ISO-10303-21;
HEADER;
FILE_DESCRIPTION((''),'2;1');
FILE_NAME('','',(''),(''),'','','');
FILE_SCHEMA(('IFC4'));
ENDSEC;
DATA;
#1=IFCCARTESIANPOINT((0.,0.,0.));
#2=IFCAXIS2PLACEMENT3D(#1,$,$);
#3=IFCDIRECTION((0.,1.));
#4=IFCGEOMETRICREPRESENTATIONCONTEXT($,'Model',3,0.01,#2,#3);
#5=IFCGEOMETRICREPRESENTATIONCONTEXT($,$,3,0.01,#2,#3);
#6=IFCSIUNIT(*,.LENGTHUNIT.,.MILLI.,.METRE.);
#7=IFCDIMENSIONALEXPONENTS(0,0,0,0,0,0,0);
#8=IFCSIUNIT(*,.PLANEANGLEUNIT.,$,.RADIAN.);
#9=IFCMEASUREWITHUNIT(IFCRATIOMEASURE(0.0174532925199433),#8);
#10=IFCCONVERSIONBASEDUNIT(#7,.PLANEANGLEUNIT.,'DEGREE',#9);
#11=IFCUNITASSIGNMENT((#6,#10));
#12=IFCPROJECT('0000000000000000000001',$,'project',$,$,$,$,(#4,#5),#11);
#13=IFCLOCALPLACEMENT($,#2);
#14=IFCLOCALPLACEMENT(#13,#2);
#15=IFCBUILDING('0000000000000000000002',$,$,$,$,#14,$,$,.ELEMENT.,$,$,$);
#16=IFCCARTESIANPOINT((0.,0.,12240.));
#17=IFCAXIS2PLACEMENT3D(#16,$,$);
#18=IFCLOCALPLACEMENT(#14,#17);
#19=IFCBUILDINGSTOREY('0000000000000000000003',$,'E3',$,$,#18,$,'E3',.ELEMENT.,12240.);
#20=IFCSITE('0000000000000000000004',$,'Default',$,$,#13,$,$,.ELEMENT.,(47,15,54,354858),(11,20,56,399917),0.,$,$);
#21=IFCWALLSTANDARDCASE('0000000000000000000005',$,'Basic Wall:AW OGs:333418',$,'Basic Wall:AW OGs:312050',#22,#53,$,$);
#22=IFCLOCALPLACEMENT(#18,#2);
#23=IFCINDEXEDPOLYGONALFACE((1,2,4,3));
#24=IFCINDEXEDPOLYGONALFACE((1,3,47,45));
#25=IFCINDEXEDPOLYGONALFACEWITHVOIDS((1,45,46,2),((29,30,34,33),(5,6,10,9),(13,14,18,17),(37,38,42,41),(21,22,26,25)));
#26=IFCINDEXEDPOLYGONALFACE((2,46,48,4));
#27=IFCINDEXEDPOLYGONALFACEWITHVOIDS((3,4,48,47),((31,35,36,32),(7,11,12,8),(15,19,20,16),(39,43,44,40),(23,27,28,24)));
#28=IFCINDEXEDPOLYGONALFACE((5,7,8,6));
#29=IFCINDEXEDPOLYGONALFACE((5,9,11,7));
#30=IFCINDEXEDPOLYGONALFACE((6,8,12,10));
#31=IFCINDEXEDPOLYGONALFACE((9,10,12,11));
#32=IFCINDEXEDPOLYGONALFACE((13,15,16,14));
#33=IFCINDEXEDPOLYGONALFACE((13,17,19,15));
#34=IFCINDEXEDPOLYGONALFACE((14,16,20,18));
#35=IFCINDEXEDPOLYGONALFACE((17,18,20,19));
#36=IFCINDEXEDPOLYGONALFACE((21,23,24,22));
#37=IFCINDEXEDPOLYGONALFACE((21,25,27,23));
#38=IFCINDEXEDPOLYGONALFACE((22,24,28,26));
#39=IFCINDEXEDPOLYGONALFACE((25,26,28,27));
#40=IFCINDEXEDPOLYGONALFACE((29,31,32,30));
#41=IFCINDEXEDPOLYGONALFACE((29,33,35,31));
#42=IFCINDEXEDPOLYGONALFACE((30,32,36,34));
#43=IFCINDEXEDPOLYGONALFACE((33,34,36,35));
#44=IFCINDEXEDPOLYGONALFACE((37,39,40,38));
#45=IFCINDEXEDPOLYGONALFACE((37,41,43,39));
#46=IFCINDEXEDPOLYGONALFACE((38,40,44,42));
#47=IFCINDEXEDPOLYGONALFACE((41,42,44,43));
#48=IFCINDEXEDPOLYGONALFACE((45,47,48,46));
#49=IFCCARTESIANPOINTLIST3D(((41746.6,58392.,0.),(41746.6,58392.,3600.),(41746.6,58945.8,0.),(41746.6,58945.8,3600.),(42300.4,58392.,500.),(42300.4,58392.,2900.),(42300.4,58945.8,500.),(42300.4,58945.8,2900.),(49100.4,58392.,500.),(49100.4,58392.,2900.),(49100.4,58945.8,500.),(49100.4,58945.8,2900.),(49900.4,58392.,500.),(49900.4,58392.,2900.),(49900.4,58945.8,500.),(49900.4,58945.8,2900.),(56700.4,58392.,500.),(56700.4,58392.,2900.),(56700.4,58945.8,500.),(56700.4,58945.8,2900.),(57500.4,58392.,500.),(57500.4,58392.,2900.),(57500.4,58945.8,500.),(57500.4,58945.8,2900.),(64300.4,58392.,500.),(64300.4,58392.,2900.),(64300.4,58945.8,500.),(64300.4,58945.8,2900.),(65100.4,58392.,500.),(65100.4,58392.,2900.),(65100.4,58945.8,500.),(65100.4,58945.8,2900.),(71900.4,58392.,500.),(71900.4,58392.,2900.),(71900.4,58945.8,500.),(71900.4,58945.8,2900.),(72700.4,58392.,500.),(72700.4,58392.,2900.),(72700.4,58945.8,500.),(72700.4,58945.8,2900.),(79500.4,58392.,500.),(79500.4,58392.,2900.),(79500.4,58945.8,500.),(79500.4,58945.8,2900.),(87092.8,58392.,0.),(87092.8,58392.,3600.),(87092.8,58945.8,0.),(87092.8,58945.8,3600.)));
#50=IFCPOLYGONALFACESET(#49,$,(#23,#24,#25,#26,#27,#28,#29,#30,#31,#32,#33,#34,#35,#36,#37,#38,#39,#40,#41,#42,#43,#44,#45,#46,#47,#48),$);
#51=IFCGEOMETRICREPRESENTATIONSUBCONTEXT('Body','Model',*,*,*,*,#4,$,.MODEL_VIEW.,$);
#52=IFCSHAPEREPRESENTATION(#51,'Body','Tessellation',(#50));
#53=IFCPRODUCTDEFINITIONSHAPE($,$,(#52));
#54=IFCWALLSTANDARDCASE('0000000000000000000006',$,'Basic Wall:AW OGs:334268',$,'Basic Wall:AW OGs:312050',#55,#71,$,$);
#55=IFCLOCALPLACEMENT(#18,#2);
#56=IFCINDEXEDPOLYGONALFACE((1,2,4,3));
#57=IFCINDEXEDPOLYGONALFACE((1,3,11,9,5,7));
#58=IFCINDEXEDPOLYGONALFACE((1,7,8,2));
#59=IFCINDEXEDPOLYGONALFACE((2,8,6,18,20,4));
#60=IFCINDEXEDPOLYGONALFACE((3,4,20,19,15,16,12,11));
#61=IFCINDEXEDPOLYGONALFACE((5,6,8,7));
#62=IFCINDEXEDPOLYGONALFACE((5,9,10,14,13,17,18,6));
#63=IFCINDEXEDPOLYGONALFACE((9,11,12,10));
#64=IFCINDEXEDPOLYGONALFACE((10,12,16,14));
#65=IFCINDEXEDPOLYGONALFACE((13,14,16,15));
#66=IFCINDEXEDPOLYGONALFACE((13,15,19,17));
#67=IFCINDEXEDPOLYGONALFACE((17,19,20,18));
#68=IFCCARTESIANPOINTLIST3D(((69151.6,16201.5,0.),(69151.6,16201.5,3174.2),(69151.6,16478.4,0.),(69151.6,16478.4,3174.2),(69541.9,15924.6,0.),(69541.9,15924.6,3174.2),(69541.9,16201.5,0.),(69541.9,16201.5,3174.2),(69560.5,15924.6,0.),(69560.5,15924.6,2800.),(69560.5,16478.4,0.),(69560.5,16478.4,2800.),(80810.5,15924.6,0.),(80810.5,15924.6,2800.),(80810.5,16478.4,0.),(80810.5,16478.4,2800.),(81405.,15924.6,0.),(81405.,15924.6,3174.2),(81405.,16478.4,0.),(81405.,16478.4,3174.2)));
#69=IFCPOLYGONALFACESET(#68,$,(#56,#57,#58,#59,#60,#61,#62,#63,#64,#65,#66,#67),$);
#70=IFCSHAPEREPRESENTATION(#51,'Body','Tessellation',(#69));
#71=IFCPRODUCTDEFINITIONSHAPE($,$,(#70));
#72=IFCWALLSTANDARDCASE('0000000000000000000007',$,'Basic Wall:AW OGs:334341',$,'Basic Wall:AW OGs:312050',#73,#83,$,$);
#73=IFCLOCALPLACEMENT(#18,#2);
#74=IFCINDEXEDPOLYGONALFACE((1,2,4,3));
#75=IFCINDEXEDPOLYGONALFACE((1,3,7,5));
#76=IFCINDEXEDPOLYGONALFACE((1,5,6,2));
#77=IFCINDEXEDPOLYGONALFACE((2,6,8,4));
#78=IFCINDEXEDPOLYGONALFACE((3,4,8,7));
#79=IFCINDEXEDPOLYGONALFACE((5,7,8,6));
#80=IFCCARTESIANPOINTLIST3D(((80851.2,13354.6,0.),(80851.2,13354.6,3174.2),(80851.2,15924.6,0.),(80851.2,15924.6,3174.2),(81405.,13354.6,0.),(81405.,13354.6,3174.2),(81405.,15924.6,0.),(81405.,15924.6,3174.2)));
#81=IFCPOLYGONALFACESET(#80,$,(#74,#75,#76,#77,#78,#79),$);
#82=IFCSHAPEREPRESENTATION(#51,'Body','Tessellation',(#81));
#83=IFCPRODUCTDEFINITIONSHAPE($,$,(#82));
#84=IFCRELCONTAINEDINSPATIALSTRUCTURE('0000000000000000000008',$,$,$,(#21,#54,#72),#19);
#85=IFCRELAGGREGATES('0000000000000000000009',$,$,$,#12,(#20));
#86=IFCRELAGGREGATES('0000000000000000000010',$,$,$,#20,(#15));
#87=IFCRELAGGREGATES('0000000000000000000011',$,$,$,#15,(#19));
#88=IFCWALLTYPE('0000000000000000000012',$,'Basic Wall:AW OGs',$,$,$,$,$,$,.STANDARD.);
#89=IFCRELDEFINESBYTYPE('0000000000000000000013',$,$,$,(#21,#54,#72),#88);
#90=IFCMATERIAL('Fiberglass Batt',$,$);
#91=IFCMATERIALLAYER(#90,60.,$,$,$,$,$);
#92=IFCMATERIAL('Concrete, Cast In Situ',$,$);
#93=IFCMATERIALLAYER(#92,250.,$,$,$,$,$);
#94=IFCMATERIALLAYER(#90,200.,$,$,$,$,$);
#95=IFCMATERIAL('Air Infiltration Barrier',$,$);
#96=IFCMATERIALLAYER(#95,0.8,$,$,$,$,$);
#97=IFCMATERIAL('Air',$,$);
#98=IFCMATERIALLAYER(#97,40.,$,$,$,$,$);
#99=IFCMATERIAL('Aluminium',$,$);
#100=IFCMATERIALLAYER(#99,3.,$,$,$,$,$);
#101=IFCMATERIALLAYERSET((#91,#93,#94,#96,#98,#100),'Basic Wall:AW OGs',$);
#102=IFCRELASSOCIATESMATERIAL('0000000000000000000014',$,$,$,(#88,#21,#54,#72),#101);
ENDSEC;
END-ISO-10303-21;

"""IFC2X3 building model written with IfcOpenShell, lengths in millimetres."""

from ifc_helpers import new_model, entity, si_unit, converted_unit, direction, frame, frame_2d, origin, place, context, subcontext, project, spatial, polyline, rectangle, outline, extrude, clip, bounded_halfspace, material, layer, layer_set, layer_usage, type_object, element, save


model = new_model("IFC2X3")

# Units and contexts
model_context = context("Model", 3, precision=0.01, world=origin(), true_north=direction((0.0, 1.0)))
context_of_model = context(None, 3, precision=0.01, world=origin(), true_north=direction((0.0, 1.0)))
body_context = subcontext(model_context, "Body", "Model", "MODEL_VIEW")
ifc_project = project(units=[si_unit("LENGTHUNIT", "METRE", prefix="MILLI"), converted_unit("PLANEANGLEUNIT", "DEGREE", entity("IfcRatioMeasure", 0.0174532925199433), si_unit("PLANEANGLEUNIT", "RADIAN"), dimensions=[0, 0, 0, 0, 0, 0, 0])], contexts=[model_context, context_of_model])

# Site, building, storey
site_placement = place(None, origin())
site = spatial("IfcSite", under=ifc_project, at=site_placement, Name="Default", CompositionType="ELEMENT", RefLatitude=(47, 15, 54, 354858), RefLongitude=(11, 20, 56, 399917), RefElevation=0.0)
building_placement = place(site_placement, origin())
building = spatial("IfcBuilding", under=site, at=building_placement, CompositionType="ELEMENT")
storey_placement = place(building_placement, frame((0.0, 0.0, 12240.0)))
storey = spatial("IfcBuildingStorey", under=building, at=storey_placement, Name="E3", LongName="E3", CompositionType="ELEMENT", Elevation=12240.0)

# Shared definitions
ifc_material_1 = material(Name="Concrete, Cast In Situ")

# Shared definitions
ifc_material_2 = material(Name="Fiberglass Batt")
ifc_layer_1 = layer(ifc_material_2, 60.0)
ifc_layer_2 = layer(ifc_material_1, 250.0)
ifc_layer_3 = layer(ifc_material_2, 200.0)
ifc_material_3 = material(Name="Air Infiltration Barrier")
ifc_layer_4 = layer(ifc_material_3, 0.8)
ifc_material_4 = material(Name="Air")
ifc_layer_5 = layer(ifc_material_4, 40.0)
ifc_material_5 = material(Name="Aluminium")
ifc_layer_6 = layer(ifc_material_5, 3.0)
ifc_layer_set_1 = layer_set([ifc_layer_1, ifc_layer_2, ifc_layer_3, ifc_layer_4, ifc_layer_5, ifc_layer_6], Name="Basic Wall:AW OGs")
wall_type_1 = type_object("IfcWallType", Name="Basic Wall:AW OGs", PredefinedType="STANDARD", material=ifc_layer_set_1)

# Wall, openings
ifc_layer_usage_1 = layer_usage(ifc_layer_set_1, "AXIS2", "NEGATIVE", 276.9)
wall_1_placement = place(storey_placement, frame((87092.8, 58668.9, 0.0), z_axis=(0.0, 0.0, 1.0), x_axis=(-1.0, 0.0, 0.0)))
wall_1 = element("IfcWallStandardCase", 1, at=wall_1_placement, inside=storey, type_object=wall_type_1, material=ifc_layer_usage_1, Name="Basic Wall:AW OGs:333418", ObjectType="Basic Wall:AW OGs:312050", context=body_context, shape_type="SweptSolid", body=[
    extrude(rectangle(XDim=45346.2, YDim=553.8, at=frame_2d((22673.1, 0.0), x_axis=(-1.0, 0.0))), origin(), (0.0, 0.0, 1.0), 3600.0),
])
opening_1_placement = place(wall_1_placement, origin())
element("IfcOpeningElement", 2, at=opening_1_placement, cuts=wall_1, ObjectType="Opening", context=body_context, shape_type="SweptSolid", body=[
    extrude(rectangle(XDim=2400.0, YDim=553.8, at=frame_2d((0.0, 0.0), x_axis=(0.0, 1.0))), frame((45069.3, 276.9, 1700.0), z_axis=(0.0, 1.0, 0.0), x_axis=(1.0, 0.0, 0.0)), (0.0, 0.0, 1.0), 2650.0),
])
opening_2_placement = place(wall_1_placement, frame((14392.4, 276.9, 500.0)))
element("IfcOpeningElement", 3, at=opening_2_placement, cuts=wall_1, ObjectType="Opening", context=body_context, shape_type="SweptSolid", body=[
    extrude(rectangle(XDim=2400.0, YDim=6800.0, at=frame_2d((1200.0, 3400.0), x_axis=(-1.0, 0.0))), frame((0.0, 0.0, 0.0), z_axis=(0.0, -1.0, 0.0), x_axis=(0.0, 0.0, 1.0)), (0.0, 0.0, 1.0), 553.8),
])
opening_3_placement = place(wall_1_placement, frame((21992.4, 276.9, 500.0)))
element("IfcOpeningElement", 4, at=opening_3_placement, cuts=wall_1, ObjectType="Opening", context=body_context, shape_type="SweptSolid", body=[
    extrude(rectangle(XDim=2400.0, YDim=6800.0, at=frame_2d((1200.0, 3400.0), x_axis=(-1.0, 0.0))), frame((0.0, 0.0, 0.0), z_axis=(0.0, -1.0, 0.0), x_axis=(0.0, 0.0, 1.0)), (0.0, 0.0, 1.0), 553.8),
])
opening_4_placement = place(wall_1_placement, frame((29592.4, 276.9, 500.0)))
element("IfcOpeningElement", 5, at=opening_4_placement, cuts=wall_1, ObjectType="Opening", context=body_context, shape_type="SweptSolid", body=[
    extrude(rectangle(XDim=2400.0, YDim=6800.0, at=frame_2d((1200.0, 3400.0), x_axis=(-1.0, 0.0))), frame((0.0, 0.0, 0.0), z_axis=(0.0, -1.0, 0.0), x_axis=(0.0, 0.0, 1.0)), (0.0, 0.0, 1.0), 553.8),
])
opening_5_placement = place(wall_1_placement, frame((37192.4, 276.9, 500.0)))
element("IfcOpeningElement", 6, at=opening_5_placement, cuts=wall_1, ObjectType="Opening", context=body_context, shape_type="SweptSolid", body=[
    extrude(rectangle(XDim=2400.0, YDim=6800.0, at=frame_2d((1200.0, 3400.0), x_axis=(-1.0, 0.0))), frame((0.0, 0.0, 0.0), z_axis=(0.0, -1.0, 0.0), x_axis=(0.0, 0.0, 1.0)), (0.0, 0.0, 1.0), 553.8),
])
opening_6_placement = place(wall_1_placement, frame((44792.4, 276.9, 500.0)))
element("IfcOpeningElement", 7, at=opening_6_placement, cuts=wall_1, ObjectType="Opening", context=body_context, shape_type="SweptSolid", body=[
    extrude(rectangle(XDim=2400.0, YDim=6800.0, at=frame_2d((1200.0, 3400.0), x_axis=(-1.0, 0.0))), frame((0.0, 0.0, 0.0), z_axis=(0.0, -1.0, 0.0), x_axis=(0.0, 0.0, 1.0)), (0.0, 0.0, 1.0), 553.8),
])

# Walls, openings
ifc_layer_usage_2 = layer_usage(ifc_layer_set_1, "AXIS2", "NEGATIVE", 276.9)
wall_2_placement = place(storey_placement, frame((69151.6, 16201.5, 0.0)))
wall_2 = element("IfcWallStandardCase", 8, at=wall_2_placement, inside=storey, type_object=wall_type_1, material=ifc_layer_usage_2, Name="Basic Wall:AW OGs:334268", ObjectType="Basic Wall:AW OGs:312050", context=body_context, shape_type="Clipping", body=[
    clip(extrude(outline(polyline([(390.3, -276.9), (11699.6, -276.9), (12253.4, -276.9), (12253.4, 276.9), (0.0, 276.9), (0.0, 0.0), (390.3, 0.0), (390.3, -276.9)])), origin(), (0.0, 0.0, 1.0), 3174.2), bounded_halfspace(frame((390.3, -276.9, 3174.2), z_axis=(0.0, 0.0, -1.0), x_axis=(0.0, -1.0, 0.0)), True, frame((390.3, -276.9, 3174.2)), polyline([(0.0, 0.0), (11309.3, 0.0), (11863.1, 0.0), (11863.1, 553.8), (-390.3, 553.8), (-390.3, 276.9), (0.0, 276.9), (0.0, 0.0)]))),
])
opening_7_placement = place(wall_2_placement, frame((11658.9, 276.9, 0.0)))
element("IfcOpeningElement", 9, at=opening_7_placement, cuts=wall_2, ObjectType="Opening", context=body_context, shape_type="SweptSolid", body=[
    extrude(rectangle(XDim=2800.0, YDim=11250.0, at=frame_2d((1400.0, 5625.0), x_axis=(-1.0, 0.0))), frame((0.0, 0.0, 0.0), z_axis=(0.0, -1.0, 0.0), x_axis=(0.0, 0.0, 1.0)), (0.0, 0.0, 1.0), 553.8),
])
ifc_layer_usage_3 = layer_usage(ifc_layer_set_1, "AXIS2", "NEGATIVE", 276.9)
wall_3_placement = place(storey_placement, frame((81128.1, 15924.6, 0.0), z_axis=(0.0, 0.0, 1.0), x_axis=(0.0, -1.0, 0.0)))
wall_3 = element("IfcWallStandardCase", 10, at=wall_3_placement, inside=storey, type_object=wall_type_1, material=ifc_layer_usage_3, Name="Basic Wall:AW OGs:334341", ObjectType="Basic Wall:AW OGs:312050", context=body_context, shape_type="Clipping", body=[
    clip(extrude(rectangle(XDim=2570.0, YDim=553.8, at=frame_2d((1285.0, 0.0), x_axis=(-1.0, 0.0))), origin(), (0.0, 0.0, 1.0), 3174.2), bounded_halfspace(frame((0.0, -276.9, 3174.2), z_axis=(0.0, 0.0, -1.0), x_axis=(1.0, 0.0, 0.0)), True, frame((0.0, -276.9, 3174.2)), polyline([(0.0, 0.0), (2570.0, 0.0), (2570.0, 553.8), (0.0, 553.8), (0.0, 0.0)]))),
])
opening_8_placement = place(wall_3_placement, origin())
element("IfcOpeningElement", 11, at=opening_8_placement, cuts=wall_3, ObjectType="Opening", context=body_context, shape_type="SweptSolid", body=[
    extrude(rectangle(XDim=2000.0, YDim=553.8, at=frame_2d((0.0, 0.0), x_axis=(0.0, 1.0))), frame((2846.9, 276.9, 1800.0), z_axis=(0.0, 1.0, 0.0), x_axis=(1.0, 0.0, 0.0)), (0.0, 0.0, 1.0), 5650.0),
])

save(model, "model.ifc")
